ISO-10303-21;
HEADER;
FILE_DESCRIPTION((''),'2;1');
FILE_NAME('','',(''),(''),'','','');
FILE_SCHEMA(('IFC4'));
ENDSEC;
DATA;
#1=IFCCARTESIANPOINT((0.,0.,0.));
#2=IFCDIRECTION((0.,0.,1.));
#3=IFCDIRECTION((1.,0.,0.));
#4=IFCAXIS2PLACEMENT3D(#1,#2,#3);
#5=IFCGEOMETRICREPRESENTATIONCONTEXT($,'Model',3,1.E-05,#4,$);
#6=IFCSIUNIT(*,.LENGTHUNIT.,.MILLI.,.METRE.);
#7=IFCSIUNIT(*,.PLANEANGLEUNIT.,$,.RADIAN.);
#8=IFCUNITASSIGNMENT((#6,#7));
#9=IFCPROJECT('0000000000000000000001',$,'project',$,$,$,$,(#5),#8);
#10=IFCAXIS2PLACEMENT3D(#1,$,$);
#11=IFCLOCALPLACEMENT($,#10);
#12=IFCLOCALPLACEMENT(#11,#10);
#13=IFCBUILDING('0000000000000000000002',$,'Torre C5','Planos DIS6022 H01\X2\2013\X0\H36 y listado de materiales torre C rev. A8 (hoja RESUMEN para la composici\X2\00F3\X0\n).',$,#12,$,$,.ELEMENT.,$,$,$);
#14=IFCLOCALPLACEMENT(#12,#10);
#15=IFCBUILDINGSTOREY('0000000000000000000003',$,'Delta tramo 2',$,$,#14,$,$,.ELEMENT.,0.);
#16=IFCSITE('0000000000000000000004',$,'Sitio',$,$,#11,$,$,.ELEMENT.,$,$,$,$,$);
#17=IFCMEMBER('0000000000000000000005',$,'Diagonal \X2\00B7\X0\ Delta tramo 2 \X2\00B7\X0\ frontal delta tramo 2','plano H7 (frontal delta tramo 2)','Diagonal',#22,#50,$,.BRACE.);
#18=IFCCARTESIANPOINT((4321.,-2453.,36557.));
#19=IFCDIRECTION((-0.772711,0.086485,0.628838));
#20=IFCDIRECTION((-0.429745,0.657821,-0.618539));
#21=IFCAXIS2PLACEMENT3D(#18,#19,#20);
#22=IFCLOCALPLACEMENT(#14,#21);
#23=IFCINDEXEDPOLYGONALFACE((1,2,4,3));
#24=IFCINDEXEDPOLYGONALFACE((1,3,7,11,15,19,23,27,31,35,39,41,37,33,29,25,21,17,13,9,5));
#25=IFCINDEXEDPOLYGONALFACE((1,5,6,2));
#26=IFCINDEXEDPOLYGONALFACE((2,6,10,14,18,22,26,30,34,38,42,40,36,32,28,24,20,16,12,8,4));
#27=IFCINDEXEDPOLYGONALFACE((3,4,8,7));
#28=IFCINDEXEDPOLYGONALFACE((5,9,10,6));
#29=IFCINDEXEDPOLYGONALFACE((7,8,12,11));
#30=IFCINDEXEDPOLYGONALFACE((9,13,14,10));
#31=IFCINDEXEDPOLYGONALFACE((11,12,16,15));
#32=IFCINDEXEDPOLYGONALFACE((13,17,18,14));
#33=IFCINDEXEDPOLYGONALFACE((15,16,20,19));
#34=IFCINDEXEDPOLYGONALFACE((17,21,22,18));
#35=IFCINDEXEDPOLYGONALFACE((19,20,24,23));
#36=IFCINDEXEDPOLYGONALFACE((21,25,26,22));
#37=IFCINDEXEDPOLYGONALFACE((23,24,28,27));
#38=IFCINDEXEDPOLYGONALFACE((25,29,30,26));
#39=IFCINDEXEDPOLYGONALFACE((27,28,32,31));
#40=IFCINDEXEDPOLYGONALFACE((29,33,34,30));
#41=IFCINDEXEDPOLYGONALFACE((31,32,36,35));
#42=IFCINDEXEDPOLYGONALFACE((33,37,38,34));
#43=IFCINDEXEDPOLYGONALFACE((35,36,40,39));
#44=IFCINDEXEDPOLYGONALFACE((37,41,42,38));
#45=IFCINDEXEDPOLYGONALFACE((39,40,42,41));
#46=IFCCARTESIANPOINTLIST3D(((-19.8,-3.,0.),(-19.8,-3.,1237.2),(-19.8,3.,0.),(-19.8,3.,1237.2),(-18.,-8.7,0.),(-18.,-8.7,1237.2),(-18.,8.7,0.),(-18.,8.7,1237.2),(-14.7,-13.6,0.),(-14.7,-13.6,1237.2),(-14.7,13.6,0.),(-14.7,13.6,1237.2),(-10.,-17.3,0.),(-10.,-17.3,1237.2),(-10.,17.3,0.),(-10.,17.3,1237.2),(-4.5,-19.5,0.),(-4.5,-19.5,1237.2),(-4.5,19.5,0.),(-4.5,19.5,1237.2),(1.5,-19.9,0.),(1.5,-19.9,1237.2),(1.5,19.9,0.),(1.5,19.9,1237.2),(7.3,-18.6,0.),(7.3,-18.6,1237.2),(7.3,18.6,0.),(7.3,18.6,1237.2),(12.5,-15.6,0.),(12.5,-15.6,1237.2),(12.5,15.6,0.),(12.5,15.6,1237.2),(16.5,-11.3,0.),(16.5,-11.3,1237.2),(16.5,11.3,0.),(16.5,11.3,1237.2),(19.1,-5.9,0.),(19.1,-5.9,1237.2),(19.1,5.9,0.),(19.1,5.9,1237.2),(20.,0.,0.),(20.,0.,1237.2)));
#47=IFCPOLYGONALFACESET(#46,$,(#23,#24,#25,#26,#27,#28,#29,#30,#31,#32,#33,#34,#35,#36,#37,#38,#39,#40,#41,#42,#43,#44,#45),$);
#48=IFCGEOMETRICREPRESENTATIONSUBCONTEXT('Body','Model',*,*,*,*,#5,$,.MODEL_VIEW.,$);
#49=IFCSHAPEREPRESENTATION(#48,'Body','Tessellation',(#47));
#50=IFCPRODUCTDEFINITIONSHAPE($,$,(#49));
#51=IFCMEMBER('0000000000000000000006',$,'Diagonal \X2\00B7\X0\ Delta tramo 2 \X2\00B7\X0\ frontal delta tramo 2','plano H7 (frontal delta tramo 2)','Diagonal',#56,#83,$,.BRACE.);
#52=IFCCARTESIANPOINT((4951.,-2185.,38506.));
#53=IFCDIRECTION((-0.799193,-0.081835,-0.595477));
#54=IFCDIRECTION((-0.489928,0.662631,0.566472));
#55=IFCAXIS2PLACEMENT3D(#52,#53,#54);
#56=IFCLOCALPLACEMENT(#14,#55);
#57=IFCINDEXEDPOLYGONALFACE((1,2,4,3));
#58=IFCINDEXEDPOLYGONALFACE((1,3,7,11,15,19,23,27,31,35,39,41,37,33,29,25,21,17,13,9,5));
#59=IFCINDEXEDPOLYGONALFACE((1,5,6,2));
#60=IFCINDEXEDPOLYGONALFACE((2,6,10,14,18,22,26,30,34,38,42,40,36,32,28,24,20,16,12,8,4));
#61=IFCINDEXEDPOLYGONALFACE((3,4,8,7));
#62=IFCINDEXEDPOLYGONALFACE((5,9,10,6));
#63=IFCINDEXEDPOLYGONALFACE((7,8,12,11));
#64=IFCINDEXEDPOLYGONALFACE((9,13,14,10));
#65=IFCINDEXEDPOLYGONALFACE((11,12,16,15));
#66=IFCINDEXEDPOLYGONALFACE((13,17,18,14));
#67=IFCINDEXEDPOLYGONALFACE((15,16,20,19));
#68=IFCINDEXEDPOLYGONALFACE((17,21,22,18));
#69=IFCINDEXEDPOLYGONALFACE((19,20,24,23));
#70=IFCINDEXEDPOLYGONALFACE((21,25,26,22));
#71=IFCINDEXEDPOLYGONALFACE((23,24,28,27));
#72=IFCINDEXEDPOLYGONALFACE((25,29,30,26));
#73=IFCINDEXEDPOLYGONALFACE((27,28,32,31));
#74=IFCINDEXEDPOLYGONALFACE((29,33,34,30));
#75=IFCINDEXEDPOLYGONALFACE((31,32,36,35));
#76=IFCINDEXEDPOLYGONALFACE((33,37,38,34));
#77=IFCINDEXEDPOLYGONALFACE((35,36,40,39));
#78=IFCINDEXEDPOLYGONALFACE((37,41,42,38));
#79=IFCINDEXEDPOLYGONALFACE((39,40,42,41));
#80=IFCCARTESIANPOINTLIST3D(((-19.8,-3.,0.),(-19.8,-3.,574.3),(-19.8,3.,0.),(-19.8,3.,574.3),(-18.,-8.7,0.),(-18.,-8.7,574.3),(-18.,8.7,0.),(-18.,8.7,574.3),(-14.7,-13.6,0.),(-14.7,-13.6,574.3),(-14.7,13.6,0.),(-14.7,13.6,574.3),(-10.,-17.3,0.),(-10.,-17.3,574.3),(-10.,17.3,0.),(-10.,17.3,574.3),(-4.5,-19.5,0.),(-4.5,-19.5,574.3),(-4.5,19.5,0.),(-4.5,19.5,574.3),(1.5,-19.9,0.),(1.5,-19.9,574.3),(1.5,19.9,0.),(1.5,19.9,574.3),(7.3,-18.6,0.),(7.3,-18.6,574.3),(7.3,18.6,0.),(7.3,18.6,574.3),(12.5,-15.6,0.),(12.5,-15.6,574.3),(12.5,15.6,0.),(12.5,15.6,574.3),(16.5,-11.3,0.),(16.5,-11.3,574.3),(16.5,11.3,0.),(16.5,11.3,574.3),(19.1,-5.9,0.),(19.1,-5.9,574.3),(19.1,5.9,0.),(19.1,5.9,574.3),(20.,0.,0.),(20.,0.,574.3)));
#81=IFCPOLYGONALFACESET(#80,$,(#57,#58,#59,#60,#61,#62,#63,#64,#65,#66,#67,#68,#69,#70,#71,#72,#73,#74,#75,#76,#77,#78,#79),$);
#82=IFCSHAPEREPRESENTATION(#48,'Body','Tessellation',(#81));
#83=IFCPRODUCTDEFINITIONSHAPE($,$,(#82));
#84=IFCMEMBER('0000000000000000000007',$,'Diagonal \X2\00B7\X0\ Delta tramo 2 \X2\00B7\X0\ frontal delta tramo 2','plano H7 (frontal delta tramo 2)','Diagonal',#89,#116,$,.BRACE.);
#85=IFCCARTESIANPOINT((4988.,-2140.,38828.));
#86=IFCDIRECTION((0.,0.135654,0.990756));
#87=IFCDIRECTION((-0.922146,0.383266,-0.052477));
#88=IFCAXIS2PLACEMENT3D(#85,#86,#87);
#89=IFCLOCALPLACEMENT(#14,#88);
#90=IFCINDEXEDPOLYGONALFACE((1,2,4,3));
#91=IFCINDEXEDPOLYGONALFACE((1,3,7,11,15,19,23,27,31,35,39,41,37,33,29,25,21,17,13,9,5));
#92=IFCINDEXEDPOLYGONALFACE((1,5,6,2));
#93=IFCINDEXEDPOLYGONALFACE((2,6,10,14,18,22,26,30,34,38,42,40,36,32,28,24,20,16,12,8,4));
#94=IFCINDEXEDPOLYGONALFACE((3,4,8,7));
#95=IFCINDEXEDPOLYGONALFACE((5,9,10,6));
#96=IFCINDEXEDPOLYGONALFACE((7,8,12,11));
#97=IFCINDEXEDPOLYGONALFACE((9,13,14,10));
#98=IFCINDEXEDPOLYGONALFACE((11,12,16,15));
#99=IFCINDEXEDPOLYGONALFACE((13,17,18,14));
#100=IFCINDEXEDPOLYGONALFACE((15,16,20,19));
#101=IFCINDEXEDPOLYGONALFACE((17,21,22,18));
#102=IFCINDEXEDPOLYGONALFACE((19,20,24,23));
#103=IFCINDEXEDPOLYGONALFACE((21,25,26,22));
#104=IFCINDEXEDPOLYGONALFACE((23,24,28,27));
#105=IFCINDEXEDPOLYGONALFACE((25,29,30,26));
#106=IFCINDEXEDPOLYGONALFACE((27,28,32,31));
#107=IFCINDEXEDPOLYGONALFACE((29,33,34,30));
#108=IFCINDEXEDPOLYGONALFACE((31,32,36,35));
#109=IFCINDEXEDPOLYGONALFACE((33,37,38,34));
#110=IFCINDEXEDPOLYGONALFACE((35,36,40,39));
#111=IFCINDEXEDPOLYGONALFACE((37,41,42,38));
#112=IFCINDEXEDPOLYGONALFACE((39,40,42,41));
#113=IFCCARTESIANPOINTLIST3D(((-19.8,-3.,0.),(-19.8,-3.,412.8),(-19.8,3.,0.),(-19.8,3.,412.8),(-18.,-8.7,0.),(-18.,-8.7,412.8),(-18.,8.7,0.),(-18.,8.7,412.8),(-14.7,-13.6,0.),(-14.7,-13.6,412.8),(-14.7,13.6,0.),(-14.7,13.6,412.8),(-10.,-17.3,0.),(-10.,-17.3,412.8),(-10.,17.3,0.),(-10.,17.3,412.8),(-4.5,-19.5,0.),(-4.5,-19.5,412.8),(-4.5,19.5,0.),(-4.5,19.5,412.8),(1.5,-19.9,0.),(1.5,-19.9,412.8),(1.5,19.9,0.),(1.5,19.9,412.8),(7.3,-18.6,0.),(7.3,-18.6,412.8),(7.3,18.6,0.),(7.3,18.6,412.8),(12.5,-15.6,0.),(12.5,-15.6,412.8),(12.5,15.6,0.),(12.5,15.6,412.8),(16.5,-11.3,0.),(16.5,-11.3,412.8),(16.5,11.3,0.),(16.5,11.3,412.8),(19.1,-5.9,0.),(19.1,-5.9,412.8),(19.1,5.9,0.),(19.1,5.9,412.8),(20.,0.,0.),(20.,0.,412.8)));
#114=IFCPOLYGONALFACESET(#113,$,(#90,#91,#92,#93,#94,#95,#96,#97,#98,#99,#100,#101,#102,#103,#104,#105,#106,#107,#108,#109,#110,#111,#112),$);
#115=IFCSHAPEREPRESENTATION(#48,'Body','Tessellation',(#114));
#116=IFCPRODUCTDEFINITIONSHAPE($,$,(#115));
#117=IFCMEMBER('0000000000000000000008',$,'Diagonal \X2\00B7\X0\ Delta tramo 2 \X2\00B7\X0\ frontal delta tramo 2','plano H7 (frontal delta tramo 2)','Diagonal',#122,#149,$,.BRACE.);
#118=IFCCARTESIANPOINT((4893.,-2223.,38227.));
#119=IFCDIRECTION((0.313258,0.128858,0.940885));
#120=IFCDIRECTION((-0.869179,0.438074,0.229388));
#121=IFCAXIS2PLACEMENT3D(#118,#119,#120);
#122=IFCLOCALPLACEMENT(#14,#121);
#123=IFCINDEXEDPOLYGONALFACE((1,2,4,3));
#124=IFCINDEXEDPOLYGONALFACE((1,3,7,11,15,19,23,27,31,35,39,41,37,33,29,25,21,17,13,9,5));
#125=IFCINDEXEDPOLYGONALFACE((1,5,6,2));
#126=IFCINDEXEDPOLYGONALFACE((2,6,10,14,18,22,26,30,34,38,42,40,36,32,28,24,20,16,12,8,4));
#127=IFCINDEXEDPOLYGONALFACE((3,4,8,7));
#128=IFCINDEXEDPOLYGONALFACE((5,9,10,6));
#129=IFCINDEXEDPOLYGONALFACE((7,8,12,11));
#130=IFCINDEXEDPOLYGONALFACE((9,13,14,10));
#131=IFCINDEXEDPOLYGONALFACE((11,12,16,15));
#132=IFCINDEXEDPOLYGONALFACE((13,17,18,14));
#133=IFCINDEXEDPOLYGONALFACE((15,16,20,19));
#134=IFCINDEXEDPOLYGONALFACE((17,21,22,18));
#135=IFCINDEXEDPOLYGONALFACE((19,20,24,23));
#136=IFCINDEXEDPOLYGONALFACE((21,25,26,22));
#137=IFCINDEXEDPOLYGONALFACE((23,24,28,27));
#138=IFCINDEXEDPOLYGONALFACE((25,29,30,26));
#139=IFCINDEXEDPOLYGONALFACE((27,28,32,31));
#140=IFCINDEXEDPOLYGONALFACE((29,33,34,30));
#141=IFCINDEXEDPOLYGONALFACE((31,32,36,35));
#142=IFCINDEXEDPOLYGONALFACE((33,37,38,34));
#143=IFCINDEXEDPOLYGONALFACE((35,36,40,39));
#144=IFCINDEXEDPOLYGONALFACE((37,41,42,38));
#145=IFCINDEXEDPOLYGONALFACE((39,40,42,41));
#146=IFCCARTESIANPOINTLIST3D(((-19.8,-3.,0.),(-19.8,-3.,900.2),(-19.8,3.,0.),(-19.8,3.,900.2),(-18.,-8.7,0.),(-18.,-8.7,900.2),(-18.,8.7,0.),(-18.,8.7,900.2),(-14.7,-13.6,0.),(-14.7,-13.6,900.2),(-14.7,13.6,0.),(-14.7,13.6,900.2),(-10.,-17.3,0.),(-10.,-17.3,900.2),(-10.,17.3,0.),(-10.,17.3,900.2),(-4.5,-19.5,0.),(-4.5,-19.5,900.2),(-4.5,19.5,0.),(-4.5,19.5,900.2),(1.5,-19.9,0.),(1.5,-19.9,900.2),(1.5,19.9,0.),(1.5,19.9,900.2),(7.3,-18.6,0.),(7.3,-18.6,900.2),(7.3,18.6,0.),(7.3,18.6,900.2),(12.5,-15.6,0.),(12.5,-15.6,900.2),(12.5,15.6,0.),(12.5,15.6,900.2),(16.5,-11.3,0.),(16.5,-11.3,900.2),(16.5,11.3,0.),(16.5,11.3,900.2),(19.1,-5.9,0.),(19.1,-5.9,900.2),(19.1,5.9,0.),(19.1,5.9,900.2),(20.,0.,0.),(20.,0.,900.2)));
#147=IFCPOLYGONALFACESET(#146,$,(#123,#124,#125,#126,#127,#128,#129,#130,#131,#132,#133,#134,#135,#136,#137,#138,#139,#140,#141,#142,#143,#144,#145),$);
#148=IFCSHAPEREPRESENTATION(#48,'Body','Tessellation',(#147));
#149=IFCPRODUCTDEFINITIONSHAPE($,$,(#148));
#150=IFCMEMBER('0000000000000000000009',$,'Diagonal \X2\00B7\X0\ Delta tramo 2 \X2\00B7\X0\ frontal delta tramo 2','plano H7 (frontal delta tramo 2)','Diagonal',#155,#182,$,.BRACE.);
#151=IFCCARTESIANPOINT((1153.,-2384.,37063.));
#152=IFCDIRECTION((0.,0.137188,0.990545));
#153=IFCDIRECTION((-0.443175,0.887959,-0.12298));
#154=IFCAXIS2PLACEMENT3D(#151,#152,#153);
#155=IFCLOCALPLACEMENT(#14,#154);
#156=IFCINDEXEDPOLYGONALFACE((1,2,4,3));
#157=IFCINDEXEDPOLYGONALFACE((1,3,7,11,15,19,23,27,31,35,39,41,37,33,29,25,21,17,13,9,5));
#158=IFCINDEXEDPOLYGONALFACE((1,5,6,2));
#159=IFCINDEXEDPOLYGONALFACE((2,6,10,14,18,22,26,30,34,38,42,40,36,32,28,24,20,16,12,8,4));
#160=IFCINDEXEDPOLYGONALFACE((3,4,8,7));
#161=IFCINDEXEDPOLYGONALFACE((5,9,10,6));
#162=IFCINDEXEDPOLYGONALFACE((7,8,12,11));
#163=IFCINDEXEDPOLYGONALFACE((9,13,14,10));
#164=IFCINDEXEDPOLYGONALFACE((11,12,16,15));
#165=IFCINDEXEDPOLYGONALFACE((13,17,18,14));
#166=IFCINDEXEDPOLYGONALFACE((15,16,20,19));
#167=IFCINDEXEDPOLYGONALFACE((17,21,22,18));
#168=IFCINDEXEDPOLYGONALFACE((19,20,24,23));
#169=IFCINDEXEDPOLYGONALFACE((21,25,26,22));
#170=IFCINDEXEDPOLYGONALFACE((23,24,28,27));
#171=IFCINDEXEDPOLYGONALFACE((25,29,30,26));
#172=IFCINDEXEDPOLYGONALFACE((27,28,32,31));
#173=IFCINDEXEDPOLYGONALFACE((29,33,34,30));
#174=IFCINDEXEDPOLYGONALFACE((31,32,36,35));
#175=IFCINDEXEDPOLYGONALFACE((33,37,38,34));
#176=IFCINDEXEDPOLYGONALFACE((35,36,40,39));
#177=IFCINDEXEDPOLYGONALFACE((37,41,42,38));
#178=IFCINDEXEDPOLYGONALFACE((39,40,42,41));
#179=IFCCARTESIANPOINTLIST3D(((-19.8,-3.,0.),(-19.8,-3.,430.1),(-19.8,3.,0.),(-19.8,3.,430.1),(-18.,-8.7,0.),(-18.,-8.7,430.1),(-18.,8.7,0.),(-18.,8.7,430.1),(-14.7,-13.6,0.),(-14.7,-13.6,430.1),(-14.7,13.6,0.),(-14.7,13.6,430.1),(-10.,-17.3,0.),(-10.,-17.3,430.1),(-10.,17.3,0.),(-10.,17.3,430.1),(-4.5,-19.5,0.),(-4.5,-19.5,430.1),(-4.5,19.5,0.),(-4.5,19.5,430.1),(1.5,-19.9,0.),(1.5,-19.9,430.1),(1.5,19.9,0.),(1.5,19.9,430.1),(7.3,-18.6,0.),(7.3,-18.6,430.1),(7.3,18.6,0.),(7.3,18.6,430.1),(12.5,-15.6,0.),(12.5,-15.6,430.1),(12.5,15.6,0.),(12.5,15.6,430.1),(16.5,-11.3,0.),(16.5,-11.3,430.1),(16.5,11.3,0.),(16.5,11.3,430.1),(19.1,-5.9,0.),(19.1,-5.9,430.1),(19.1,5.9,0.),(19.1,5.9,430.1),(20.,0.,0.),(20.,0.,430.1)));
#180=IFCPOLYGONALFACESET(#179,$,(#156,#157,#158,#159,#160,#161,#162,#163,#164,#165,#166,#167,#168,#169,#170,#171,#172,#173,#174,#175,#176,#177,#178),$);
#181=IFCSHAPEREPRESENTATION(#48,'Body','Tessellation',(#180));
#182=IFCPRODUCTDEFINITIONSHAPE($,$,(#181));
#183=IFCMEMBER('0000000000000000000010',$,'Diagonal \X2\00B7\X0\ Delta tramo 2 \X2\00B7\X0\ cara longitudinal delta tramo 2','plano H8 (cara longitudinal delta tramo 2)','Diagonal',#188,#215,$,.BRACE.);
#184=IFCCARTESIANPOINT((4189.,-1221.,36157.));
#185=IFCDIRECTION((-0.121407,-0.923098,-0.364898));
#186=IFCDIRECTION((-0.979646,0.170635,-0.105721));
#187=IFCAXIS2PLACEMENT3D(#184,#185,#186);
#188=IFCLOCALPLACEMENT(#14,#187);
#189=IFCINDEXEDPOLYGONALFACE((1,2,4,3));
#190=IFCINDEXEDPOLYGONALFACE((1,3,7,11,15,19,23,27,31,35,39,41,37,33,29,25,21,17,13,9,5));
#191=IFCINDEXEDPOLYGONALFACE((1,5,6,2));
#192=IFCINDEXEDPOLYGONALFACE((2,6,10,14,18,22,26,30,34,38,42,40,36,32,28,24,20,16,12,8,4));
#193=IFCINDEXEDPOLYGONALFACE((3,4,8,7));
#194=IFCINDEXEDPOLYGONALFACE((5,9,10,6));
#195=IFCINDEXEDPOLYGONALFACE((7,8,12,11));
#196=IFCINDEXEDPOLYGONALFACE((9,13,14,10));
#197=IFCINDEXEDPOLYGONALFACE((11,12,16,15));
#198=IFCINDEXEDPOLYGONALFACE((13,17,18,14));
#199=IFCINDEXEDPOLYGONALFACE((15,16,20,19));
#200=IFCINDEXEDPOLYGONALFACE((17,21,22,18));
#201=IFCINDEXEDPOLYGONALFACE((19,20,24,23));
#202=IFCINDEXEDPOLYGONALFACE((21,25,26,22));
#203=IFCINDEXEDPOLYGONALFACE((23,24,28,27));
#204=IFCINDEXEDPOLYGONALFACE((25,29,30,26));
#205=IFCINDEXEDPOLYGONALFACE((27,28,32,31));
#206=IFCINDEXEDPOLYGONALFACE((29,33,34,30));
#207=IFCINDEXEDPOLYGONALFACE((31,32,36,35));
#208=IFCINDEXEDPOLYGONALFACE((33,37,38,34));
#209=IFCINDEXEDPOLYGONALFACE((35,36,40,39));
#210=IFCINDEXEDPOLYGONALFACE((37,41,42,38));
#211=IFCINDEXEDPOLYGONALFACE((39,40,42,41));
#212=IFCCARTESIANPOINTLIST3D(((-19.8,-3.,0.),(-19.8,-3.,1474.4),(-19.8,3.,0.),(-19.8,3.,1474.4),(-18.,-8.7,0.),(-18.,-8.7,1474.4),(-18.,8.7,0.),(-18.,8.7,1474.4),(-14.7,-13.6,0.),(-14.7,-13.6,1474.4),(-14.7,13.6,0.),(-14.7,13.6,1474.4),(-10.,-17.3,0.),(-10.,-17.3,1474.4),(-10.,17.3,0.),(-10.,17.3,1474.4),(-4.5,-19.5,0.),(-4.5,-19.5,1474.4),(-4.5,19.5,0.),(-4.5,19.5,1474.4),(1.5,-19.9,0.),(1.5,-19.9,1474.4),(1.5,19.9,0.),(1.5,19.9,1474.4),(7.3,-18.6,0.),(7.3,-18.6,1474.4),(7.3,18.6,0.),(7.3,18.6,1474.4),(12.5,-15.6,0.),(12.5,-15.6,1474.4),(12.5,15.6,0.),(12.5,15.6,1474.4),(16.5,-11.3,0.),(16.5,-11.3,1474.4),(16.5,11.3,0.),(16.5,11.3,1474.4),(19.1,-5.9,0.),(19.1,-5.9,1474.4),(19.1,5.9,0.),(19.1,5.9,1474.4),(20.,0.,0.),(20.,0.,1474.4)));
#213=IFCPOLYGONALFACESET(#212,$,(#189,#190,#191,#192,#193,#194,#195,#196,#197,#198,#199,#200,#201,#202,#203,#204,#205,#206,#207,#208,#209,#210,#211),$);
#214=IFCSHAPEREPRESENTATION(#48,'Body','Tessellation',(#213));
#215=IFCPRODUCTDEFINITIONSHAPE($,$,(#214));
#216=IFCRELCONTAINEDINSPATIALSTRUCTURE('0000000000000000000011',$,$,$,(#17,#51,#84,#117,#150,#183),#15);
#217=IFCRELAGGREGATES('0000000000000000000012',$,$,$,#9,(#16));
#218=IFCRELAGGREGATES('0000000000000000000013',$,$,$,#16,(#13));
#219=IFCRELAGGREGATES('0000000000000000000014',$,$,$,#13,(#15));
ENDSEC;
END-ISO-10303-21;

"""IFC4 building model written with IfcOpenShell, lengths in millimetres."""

from ifc_helpers import new_model, si_unit, frame, origin, origin_with_axes, place, context, subcontext, project, spatial, circle, extrude, element, save


model = new_model("IFC4")

# Units and contexts
model_context = context("Model", 3, precision=1e-05, world=origin_with_axes())
body_context = subcontext(model_context, "Body", "Model", "MODEL_VIEW")
ifc_project = project(units=[si_unit("LENGTHUNIT", "METRE", prefix="MILLI"), si_unit("PLANEANGLEUNIT", "RADIAN")], contexts=[model_context])

# Site, building, storey
site_placement = place(None, origin())
site = spatial("IfcSite", under=ifc_project, at=site_placement, Name="Sitio", CompositionType="ELEMENT")
building_placement = place(site_placement, origin())
building = spatial("IfcBuilding", under=site, at=building_placement, Name="Torre C5", Description="Planos DIS6022 H01–H36 y listado de materiales torre C rev. A8 (hoja RESUMEN para la composición).", CompositionType="ELEMENT")
storey_placement = place(building_placement, origin())
storey = spatial("IfcBuildingStorey", under=building, at=storey_placement, Name="Delta tramo 2", CompositionType="ELEMENT", Elevation=0.0)

# Members
member_1_placement = place(storey_placement, frame((4321.0, -2453.0, 36557.0), z_axis=(-0.772711, 0.086485, 0.628838), x_axis=(-0.429745, 0.657821, -0.618539)))
element("IfcMember", 1, at=member_1_placement, inside=storey, Name="Diagonal · Delta tramo 2 · frontal delta tramo 2", Description="plano H7 (frontal delta tramo 2)", ObjectType="Diagonal", PredefinedType="BRACE", context=body_context, shape_type="SweptSolid", body=[
    extrude(circle(Radius=20.0), None, (0.0, 0.0, 1.0), 1237.2),
])
member_2_placement = place(storey_placement, frame((4951.0, -2185.0, 38506.0), z_axis=(-0.799193, -0.081835, -0.595477), x_axis=(-0.489928, 0.662631, 0.566472)))
element("IfcMember", 2, at=member_2_placement, inside=storey, Name="Diagonal · Delta tramo 2 · frontal delta tramo 2", Description="plano H7 (frontal delta tramo 2)", ObjectType="Diagonal", PredefinedType="BRACE", context=body_context, shape_type="SweptSolid", body=[
    extrude(circle(Radius=20.0), None, (0.0, 0.0, 1.0), 574.3),
])
member_3_placement = place(storey_placement, frame((4988.0, -2140.0, 38828.0), z_axis=(0.0, 0.135654, 0.990756), x_axis=(-0.922146, 0.383266, -0.052477)))
element("IfcMember", 3, at=member_3_placement, inside=storey, Name="Diagonal · Delta tramo 2 · frontal delta tramo 2", Description="plano H7 (frontal delta tramo 2)", ObjectType="Diagonal", PredefinedType="BRACE", context=body_context, shape_type="SweptSolid", body=[
    extrude(circle(Radius=20.0), None, (0.0, 0.0, 1.0), 412.8),
])
member_4_placement = place(storey_placement, frame((4893.0, -2223.0, 38227.0), z_axis=(0.313258, 0.128858, 0.940885), x_axis=(-0.869179, 0.438074, 0.229388)))
element("IfcMember", 4, at=member_4_placement, inside=storey, Name="Diagonal · Delta tramo 2 · frontal delta tramo 2", Description="plano H7 (frontal delta tramo 2)", ObjectType="Diagonal", PredefinedType="BRACE", context=body_context, shape_type="SweptSolid", body=[
    extrude(circle(Radius=20.0), None, (0.0, 0.0, 1.0), 900.2),
])
for number, where, z_axis, x_axis, name in (
    (5, (1153.0, -2384.0, 37063.0), (0.0, 0.137188, 0.990545), (-0.443175, 0.887959, -0.12298), "Diagonal · Delta tramo 2 · frontal delta tramo 2"),
):
    element("IfcMember", number, at=place(storey_placement, frame(where, z_axis=z_axis, x_axis=x_axis)), inside=storey, Name=name, Description="plano H7 (frontal delta tramo 2)", ObjectType="Diagonal", PredefinedType="BRACE", context=body_context, shape_type="SweptSolid", body=[
        extrude(circle(Radius=20.0), None, (0.0, 0.0, 1.0), 430.1),
    ])
member_5_placement = place(storey_placement, frame((4189.0, -1221.0, 36157.0), z_axis=(-0.121407, -0.923098, -0.364898), x_axis=(-0.979646, 0.170635, -0.105721)))
element("IfcMember", 6, at=member_5_placement, inside=storey, Name="Diagonal · Delta tramo 2 · cara longitudinal delta tramo 2", Description="plano H8 (cara longitudinal delta tramo 2)", ObjectType="Diagonal", PredefinedType="BRACE", context=body_context, shape_type="SweptSolid", body=[
    extrude(circle(Radius=20.0), None, (0.0, 0.0, 1.0), 1474.4),
])

save(model, "model.ifc")
